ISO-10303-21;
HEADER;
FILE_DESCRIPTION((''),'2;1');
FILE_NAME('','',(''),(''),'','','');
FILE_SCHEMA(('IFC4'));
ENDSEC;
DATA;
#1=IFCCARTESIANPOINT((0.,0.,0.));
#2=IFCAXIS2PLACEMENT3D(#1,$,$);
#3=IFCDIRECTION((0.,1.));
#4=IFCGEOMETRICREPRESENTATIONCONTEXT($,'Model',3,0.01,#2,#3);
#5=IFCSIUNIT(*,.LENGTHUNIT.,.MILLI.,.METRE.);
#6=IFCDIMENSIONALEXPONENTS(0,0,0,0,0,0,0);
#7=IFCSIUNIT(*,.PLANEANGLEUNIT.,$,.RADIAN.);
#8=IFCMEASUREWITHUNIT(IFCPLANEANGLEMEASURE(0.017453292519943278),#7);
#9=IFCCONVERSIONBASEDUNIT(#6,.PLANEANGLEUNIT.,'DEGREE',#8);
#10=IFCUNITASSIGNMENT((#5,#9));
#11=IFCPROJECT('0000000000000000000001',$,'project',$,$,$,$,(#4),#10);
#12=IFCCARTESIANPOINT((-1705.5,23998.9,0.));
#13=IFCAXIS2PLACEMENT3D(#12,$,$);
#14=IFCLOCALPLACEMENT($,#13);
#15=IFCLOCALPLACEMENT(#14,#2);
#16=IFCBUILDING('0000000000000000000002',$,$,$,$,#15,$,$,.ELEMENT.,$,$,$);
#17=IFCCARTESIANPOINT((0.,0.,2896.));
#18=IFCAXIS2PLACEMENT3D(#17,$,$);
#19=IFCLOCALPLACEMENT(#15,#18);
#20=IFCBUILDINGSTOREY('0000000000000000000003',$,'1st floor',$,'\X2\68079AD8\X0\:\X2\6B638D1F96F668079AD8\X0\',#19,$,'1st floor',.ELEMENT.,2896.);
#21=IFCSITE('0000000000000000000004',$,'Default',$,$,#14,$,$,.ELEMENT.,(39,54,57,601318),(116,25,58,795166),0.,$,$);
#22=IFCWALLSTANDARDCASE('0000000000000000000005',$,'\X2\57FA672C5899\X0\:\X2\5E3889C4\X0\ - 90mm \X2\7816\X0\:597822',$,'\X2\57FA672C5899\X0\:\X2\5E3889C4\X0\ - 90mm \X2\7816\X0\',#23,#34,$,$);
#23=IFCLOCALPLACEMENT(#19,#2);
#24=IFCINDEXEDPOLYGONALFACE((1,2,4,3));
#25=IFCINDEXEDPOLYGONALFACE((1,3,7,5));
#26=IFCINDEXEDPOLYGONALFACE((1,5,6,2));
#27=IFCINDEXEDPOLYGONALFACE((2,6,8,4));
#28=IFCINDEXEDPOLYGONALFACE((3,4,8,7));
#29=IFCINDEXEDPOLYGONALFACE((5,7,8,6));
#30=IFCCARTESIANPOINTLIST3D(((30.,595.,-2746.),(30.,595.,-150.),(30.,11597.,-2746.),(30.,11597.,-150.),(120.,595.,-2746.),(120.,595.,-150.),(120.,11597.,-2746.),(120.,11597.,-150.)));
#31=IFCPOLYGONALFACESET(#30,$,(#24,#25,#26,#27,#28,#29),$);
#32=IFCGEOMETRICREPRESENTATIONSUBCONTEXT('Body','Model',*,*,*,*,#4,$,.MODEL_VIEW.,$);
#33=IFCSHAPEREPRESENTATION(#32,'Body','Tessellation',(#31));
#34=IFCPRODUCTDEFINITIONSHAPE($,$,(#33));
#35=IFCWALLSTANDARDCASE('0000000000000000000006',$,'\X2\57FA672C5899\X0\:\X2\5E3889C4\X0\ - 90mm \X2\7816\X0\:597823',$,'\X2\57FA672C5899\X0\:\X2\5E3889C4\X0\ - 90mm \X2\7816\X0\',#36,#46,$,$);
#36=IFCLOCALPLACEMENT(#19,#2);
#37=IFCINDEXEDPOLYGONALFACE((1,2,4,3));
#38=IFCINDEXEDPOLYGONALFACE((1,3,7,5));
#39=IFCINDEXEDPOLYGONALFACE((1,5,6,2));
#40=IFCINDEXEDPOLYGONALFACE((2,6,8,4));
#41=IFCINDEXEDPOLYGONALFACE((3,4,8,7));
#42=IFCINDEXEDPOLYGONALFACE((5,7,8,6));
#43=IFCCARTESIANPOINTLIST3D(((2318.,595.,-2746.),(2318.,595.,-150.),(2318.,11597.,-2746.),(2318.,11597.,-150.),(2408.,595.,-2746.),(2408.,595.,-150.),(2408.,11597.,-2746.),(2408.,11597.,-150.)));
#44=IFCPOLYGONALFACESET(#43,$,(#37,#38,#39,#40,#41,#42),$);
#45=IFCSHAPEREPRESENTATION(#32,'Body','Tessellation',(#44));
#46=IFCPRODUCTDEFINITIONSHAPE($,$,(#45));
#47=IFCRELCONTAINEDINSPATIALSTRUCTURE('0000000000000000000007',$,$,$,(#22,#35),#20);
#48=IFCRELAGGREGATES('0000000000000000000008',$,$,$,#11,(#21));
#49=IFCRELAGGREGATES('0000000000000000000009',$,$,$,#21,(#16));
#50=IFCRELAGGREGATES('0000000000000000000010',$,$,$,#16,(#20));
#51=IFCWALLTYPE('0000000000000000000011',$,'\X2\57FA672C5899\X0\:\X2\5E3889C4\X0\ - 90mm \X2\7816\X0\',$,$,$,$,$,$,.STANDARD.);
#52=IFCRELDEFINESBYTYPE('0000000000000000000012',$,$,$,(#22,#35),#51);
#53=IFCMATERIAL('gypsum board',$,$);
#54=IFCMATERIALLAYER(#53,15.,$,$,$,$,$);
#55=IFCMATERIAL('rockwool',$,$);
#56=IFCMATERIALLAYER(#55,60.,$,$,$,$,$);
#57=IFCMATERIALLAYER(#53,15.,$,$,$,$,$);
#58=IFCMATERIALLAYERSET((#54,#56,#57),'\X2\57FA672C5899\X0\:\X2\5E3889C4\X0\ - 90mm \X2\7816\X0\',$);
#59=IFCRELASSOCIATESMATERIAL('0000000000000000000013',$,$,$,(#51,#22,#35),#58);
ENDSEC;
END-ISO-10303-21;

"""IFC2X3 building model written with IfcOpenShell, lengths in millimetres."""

from ifc_helpers import new_model, entity, si_unit, converted_unit, direction, frame, frame_2d, origin, place, context, subcontext, project, spatial, rectangle, extrude, material, layer, layer_set, layer_usage, type_object, element, save


model = new_model("IFC2X3")

# Units and contexts
model_context = context("Model", 3, precision=0.01, world=origin(), true_north=direction((0.0, 1.0)))
body_context = subcontext(model_context, "Body", "Model", "MODEL_VIEW")
ifc_project = project(units=[si_unit("LENGTHUNIT", "METRE", prefix="MILLI"), converted_unit("PLANEANGLEUNIT", "DEGREE", entity("IfcPlaneAngleMeasure", 0.017453292519943278), si_unit("PLANEANGLEUNIT", "RADIAN"), dimensions=[0, 0, 0, 0, 0, 0, 0])], contexts=[model_context])

# Site, building, storey
site_placement = place(None, frame((-1705.5, 23998.9, 0.0)))
site = spatial("IfcSite", under=ifc_project, at=site_placement, Name="Default", CompositionType="ELEMENT", RefLatitude=(39, 54, 57, 601318), RefLongitude=(116, 25, 58, 795166), RefElevation=0.0)
building_placement = place(site_placement, origin())
building = spatial("IfcBuilding", under=site, at=building_placement, CompositionType="ELEMENT")
storey_placement = place(building_placement, frame((0.0, 0.0, 2896.0)))
storey = spatial("IfcBuildingStorey", under=building, at=storey_placement, Name="1st floor", ObjectType="标高:正负零标高", LongName="1st floor", CompositionType="ELEMENT", Elevation=2896.0)

# Walls
ifc_material_1 = material(Name="gypsum board")
ifc_layer_1 = layer(ifc_material_1, 15.0)
ifc_material_2 = material(Name="rockwool")
ifc_layer_2 = layer(ifc_material_2, 60.0)
ifc_layer_3 = layer(ifc_material_1, 15.0)
ifc_layer_set = layer_set([ifc_layer_1, ifc_layer_2, ifc_layer_3], Name="基本墙:常规 - 90mm 砖")
ifc_layer_usage_1 = layer_usage(ifc_layer_set, "AXIS2", "NEGATIVE", 45.0)
wall_type = type_object("IfcWallType", Name="基本墙:常规 - 90mm 砖", PredefinedType="STANDARD", material=ifc_layer_set)
wall_1_placement = place(storey_placement, frame((75.0, 11597.0, -2746.0), z_axis=(0.0, 0.0, 1.0), x_axis=(0.0, -1.0, 0.0)))
element("IfcWallStandardCase", 1, at=wall_1_placement, inside=storey, type_object=wall_type, material=ifc_layer_usage_1, Name="基本墙:常规 - 90mm 砖:597822", ObjectType="基本墙:常规 - 90mm 砖", context=body_context, shape_type="SweptSolid", body=[
    extrude(rectangle(XDim=11002.0, YDim=90.0, at=frame_2d((5501.0, 0.0), x_axis=(-1.0, 0.0))), origin(), (0.0, 0.0, 1.0), 2596.0),
])
ifc_layer_usage_2 = layer_usage(ifc_layer_set, "AXIS2", "NEGATIVE", 45.0)
wall_2_placement = place(storey_placement, frame((2363.0, 11597.0, -2746.0), z_axis=(0.0, 0.0, 1.0), x_axis=(0.0, -1.0, 0.0)))
element("IfcWallStandardCase", 2, at=wall_2_placement, inside=storey, type_object=wall_type, material=ifc_layer_usage_2, Name="基本墙:常规 - 90mm 砖:597823", ObjectType="基本墙:常规 - 90mm 砖", context=body_context, shape_type="SweptSolid", body=[
    extrude(rectangle(XDim=11002.0, YDim=90.0, at=frame_2d((5501.0, 0.0), x_axis=(-1.0, 0.0))), origin(), (0.0, 0.0, 1.0), 2596.0),
])

save(model, "model.ifc")
